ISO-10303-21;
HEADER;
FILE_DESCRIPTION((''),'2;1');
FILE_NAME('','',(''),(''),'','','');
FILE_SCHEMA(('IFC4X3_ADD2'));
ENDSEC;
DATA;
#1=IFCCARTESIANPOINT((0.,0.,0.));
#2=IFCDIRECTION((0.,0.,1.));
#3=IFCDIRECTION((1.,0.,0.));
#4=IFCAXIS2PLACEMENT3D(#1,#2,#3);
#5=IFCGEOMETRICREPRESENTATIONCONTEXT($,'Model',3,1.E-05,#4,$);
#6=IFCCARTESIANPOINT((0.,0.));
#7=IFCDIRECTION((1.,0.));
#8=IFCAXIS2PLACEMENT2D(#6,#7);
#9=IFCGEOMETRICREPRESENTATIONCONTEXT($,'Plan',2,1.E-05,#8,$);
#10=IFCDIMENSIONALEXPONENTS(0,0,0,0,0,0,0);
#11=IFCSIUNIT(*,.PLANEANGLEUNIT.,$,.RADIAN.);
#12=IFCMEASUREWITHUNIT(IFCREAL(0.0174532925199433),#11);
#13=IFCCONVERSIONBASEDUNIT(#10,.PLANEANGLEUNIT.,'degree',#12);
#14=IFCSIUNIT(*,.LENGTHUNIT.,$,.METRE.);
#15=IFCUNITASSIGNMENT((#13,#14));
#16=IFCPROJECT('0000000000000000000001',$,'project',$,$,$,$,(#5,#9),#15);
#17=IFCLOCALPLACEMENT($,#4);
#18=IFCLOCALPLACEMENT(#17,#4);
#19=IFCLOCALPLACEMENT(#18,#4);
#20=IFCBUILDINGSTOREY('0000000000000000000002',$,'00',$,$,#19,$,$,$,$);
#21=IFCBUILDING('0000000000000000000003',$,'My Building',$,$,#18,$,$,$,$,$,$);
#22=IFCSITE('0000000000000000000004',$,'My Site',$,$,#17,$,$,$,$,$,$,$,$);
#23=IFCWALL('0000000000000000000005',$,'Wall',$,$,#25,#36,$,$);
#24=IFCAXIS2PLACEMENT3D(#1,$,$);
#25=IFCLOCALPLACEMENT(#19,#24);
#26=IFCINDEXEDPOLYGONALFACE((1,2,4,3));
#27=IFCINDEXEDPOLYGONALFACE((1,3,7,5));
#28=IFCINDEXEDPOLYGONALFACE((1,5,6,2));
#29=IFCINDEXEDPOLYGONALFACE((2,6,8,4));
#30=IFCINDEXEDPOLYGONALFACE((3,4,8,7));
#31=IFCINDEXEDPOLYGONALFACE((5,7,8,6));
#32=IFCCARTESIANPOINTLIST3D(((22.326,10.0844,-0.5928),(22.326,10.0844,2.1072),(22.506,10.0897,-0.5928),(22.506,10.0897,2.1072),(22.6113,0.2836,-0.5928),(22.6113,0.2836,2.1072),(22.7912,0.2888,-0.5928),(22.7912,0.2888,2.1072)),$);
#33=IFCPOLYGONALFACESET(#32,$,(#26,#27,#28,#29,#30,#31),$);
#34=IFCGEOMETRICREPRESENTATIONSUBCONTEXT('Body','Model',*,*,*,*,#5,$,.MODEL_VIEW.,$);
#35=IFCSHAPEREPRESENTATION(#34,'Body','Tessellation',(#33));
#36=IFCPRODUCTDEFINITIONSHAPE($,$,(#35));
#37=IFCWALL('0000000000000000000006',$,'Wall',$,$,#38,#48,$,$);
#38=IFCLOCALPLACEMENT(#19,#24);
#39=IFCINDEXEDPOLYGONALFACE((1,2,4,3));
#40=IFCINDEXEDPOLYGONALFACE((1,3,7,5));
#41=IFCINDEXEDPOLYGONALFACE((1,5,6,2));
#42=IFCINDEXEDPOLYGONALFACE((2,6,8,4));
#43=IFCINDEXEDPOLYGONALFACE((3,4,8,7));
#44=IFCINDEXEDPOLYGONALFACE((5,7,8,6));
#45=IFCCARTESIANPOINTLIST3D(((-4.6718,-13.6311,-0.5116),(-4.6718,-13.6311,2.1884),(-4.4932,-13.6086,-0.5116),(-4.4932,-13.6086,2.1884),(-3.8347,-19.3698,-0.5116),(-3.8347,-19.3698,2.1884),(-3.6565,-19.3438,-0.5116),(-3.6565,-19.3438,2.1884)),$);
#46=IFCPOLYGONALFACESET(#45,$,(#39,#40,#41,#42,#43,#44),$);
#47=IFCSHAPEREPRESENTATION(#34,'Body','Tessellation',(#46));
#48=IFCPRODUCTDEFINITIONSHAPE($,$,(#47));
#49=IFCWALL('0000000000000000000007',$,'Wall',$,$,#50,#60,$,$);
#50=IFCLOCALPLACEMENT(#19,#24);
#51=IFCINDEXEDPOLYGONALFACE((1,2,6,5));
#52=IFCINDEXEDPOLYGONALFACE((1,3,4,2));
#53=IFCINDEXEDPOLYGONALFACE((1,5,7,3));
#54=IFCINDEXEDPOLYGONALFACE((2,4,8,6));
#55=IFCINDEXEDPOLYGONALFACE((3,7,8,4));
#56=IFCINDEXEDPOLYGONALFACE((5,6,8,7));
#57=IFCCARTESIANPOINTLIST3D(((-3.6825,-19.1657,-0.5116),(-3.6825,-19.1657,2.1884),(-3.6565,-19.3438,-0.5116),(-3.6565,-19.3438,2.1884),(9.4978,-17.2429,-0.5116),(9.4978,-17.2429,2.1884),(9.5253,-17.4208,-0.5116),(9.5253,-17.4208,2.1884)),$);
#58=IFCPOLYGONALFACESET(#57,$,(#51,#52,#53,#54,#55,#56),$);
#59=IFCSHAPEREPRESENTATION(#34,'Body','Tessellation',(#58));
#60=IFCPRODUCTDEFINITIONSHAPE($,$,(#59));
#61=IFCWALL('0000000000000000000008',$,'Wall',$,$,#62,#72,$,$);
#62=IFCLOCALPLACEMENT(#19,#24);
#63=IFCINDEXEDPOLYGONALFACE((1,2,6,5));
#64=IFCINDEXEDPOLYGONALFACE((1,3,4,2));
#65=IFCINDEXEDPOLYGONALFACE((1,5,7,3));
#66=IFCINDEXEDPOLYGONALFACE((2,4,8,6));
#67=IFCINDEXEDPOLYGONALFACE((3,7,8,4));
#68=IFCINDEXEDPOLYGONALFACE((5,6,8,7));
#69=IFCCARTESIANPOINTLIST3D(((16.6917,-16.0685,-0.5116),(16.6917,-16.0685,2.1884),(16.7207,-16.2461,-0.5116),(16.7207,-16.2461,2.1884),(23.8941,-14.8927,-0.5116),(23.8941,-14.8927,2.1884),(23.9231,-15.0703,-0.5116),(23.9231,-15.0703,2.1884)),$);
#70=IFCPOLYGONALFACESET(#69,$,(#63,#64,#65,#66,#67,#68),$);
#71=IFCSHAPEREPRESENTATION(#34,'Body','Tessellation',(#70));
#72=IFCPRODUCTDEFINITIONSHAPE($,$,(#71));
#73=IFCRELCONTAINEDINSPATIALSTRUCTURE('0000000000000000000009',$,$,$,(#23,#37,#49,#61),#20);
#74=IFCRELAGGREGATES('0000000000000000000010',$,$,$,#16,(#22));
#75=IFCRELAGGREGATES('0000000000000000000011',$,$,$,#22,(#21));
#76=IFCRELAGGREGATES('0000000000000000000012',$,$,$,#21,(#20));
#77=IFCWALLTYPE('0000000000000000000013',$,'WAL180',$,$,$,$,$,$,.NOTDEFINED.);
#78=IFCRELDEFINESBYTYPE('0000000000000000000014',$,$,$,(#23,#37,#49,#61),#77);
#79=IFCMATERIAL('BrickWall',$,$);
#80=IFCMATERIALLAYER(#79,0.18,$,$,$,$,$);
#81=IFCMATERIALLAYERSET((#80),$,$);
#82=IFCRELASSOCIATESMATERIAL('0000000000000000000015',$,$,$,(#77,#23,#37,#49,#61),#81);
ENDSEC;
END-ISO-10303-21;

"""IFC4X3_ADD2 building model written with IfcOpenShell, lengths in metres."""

from ifc_helpers import new_model, entity, si_unit, converted_unit, frame, origin_with_axes, origin_2d_with_axis, place, context, subcontext, project, spatial, indexed_curve, outline, extrude, clip, halfspace, material, layer, layer_set, layer_usage, type_object, element, save


model = new_model("IFC4X3_ADD2")

# Units and contexts
model_context = context("Model", 3, precision=1e-05, world=origin_with_axes())
plan_context = context("Plan", 2, precision=1e-05, world=origin_2d_with_axis())
body_context = subcontext(model_context, "Body", "Model", "MODEL_VIEW")
ifc_project = project(units=[converted_unit("PLANEANGLEUNIT", "degree", entity("IfcReal", 0.0174532925199433), si_unit("PLANEANGLEUNIT", "RADIAN"), dimensions=[0, 0, 0, 0, 0, 0, 0]), si_unit("LENGTHUNIT", "METRE")], contexts=[model_context, plan_context])

# Site, building, storey
site_placement = place(None, origin_with_axes())
site = spatial("IfcSite", under=ifc_project, at=site_placement, Name="My Site")
building_placement = place(site_placement, origin_with_axes())
building = spatial("IfcBuilding", under=site, at=building_placement, Name="My Building")
storey_placement = place(building_placement, origin_with_axes())
storey = spatial("IfcBuildingStorey", under=building, at=storey_placement, Name="00")

# Walls
ifc_material = material(Name="BrickWall")
ifc_layer = layer(ifc_material, 0.18)
ifc_layer_set = layer_set([ifc_layer])
wall_type = type_object("IfcWallType", Name="WAL180", PredefinedType="NOTDEFINED", material=ifc_layer_set)
ifc_layer_usage_1 = layer_usage(ifc_layer_set, "AXIS2", "POSITIVE", 0.0)
wall_1_placement = place(storey_placement, frame((22.7912, 0.2888, -0.5928), z_axis=(0.0, 0.0, 1.0), x_axis=(-0.029096, 0.999577, 0.0)))
element("IfcWall", 1, at=wall_1_placement, inside=storey, type_object=wall_type, material=ifc_layer_usage_1, Name="Wall", context=body_context, shape_type="SweptSolid", body=[
    extrude(outline(indexed_curve([(0.0, 0.0), (0.0, 0.18), (9.805, 0.18), (9.805, 0.0), (0.0, 0.0)], self_intersect=False)), origin_with_axes(), (0.0, 0.0, 1.0), 2.7),
])
ifc_layer_usage_2 = layer_usage(ifc_layer_set, "AXIS2", "POSITIVE", 0.0)
wall_2_placement = place(storey_placement, frame((-3.6565, -19.3438, -0.5116), z_axis=(0.0, 0.0, 1.0), x_axis=(-0.144352, 0.989526, 0.0)))
element("IfcWall", 2, at=wall_2_placement, inside=storey, type_object=wall_type, material=ifc_layer_usage_2, Name="Wall", context=body_context, shape_type="Clipping", body=[
    clip(extrude(outline(indexed_curve([(0.0, 0.0), (0.0, 0.18), (10.4218, 0.18), (10.4218, 0.0), (0.0, 0.0)], self_intersect=False)), origin_with_axes(), (0.0, 0.0, 1.0), 2.7), halfspace(frame((5.7959, 0.0, 0.5116), z_axis=(0.999812, -0.0194, 0.0), x_axis=(-0.0194, -0.999812, 0.0)), False)),
])
ifc_layer_usage_3 = layer_usage(ifc_layer_set, "AXIS2", "POSITIVE", 0.0)
wall_3_placement = place(storey_placement, frame((-3.6565, -19.3438, -0.5116), z_axis=(0.0, 0.0, 1.0), x_axis=(0.989526, 0.144352, 0.0)))
element("IfcWall", 3, at=wall_3_placement, inside=storey, type_object=wall_type, material=ifc_layer_usage_3, Name="Wall", context=body_context, shape_type="Clipping", body=[
    clip(extrude(outline(indexed_curve([(0.0, 0.0), (0.0, 0.18), (23.9284, 0.18), (23.9284, 0.0), (0.0, 0.0)], self_intersect=False)), origin_with_axes(), (0.0, 0.0, 1.0), 2.7), halfspace(frame((13.3213, 0.0, 0.5116), z_axis=(0.999962, 0.008712, 0.0), x_axis=(0.008712, -0.999962, 0.0)), False)),
])
ifc_layer_usage_4 = layer_usage(ifc_layer_set, "AXIS2", "POSITIVE", 0.0)
wall_4_placement = place(storey_placement, frame((16.7207, -16.2461, -0.5116), z_axis=(0.0, 0.0, 1.0), x_axis=(0.986935, 0.161121, 0.0)))
element("IfcWall", 4, at=wall_4_placement, inside=storey, type_object=wall_type, material=ifc_layer_usage_4, Name="Wall", context=body_context, shape_type="SweptSolid", body=[
    extrude(outline(indexed_curve([(0.0, 0.0), (0.0, 0.18), (7.2977, 0.18), (7.2977, 0.0), (0.0, 0.0)], self_intersect=False)), origin_with_axes(), (0.0, 0.0, 1.0), 2.7),
])

save(model, "model.ifc")
